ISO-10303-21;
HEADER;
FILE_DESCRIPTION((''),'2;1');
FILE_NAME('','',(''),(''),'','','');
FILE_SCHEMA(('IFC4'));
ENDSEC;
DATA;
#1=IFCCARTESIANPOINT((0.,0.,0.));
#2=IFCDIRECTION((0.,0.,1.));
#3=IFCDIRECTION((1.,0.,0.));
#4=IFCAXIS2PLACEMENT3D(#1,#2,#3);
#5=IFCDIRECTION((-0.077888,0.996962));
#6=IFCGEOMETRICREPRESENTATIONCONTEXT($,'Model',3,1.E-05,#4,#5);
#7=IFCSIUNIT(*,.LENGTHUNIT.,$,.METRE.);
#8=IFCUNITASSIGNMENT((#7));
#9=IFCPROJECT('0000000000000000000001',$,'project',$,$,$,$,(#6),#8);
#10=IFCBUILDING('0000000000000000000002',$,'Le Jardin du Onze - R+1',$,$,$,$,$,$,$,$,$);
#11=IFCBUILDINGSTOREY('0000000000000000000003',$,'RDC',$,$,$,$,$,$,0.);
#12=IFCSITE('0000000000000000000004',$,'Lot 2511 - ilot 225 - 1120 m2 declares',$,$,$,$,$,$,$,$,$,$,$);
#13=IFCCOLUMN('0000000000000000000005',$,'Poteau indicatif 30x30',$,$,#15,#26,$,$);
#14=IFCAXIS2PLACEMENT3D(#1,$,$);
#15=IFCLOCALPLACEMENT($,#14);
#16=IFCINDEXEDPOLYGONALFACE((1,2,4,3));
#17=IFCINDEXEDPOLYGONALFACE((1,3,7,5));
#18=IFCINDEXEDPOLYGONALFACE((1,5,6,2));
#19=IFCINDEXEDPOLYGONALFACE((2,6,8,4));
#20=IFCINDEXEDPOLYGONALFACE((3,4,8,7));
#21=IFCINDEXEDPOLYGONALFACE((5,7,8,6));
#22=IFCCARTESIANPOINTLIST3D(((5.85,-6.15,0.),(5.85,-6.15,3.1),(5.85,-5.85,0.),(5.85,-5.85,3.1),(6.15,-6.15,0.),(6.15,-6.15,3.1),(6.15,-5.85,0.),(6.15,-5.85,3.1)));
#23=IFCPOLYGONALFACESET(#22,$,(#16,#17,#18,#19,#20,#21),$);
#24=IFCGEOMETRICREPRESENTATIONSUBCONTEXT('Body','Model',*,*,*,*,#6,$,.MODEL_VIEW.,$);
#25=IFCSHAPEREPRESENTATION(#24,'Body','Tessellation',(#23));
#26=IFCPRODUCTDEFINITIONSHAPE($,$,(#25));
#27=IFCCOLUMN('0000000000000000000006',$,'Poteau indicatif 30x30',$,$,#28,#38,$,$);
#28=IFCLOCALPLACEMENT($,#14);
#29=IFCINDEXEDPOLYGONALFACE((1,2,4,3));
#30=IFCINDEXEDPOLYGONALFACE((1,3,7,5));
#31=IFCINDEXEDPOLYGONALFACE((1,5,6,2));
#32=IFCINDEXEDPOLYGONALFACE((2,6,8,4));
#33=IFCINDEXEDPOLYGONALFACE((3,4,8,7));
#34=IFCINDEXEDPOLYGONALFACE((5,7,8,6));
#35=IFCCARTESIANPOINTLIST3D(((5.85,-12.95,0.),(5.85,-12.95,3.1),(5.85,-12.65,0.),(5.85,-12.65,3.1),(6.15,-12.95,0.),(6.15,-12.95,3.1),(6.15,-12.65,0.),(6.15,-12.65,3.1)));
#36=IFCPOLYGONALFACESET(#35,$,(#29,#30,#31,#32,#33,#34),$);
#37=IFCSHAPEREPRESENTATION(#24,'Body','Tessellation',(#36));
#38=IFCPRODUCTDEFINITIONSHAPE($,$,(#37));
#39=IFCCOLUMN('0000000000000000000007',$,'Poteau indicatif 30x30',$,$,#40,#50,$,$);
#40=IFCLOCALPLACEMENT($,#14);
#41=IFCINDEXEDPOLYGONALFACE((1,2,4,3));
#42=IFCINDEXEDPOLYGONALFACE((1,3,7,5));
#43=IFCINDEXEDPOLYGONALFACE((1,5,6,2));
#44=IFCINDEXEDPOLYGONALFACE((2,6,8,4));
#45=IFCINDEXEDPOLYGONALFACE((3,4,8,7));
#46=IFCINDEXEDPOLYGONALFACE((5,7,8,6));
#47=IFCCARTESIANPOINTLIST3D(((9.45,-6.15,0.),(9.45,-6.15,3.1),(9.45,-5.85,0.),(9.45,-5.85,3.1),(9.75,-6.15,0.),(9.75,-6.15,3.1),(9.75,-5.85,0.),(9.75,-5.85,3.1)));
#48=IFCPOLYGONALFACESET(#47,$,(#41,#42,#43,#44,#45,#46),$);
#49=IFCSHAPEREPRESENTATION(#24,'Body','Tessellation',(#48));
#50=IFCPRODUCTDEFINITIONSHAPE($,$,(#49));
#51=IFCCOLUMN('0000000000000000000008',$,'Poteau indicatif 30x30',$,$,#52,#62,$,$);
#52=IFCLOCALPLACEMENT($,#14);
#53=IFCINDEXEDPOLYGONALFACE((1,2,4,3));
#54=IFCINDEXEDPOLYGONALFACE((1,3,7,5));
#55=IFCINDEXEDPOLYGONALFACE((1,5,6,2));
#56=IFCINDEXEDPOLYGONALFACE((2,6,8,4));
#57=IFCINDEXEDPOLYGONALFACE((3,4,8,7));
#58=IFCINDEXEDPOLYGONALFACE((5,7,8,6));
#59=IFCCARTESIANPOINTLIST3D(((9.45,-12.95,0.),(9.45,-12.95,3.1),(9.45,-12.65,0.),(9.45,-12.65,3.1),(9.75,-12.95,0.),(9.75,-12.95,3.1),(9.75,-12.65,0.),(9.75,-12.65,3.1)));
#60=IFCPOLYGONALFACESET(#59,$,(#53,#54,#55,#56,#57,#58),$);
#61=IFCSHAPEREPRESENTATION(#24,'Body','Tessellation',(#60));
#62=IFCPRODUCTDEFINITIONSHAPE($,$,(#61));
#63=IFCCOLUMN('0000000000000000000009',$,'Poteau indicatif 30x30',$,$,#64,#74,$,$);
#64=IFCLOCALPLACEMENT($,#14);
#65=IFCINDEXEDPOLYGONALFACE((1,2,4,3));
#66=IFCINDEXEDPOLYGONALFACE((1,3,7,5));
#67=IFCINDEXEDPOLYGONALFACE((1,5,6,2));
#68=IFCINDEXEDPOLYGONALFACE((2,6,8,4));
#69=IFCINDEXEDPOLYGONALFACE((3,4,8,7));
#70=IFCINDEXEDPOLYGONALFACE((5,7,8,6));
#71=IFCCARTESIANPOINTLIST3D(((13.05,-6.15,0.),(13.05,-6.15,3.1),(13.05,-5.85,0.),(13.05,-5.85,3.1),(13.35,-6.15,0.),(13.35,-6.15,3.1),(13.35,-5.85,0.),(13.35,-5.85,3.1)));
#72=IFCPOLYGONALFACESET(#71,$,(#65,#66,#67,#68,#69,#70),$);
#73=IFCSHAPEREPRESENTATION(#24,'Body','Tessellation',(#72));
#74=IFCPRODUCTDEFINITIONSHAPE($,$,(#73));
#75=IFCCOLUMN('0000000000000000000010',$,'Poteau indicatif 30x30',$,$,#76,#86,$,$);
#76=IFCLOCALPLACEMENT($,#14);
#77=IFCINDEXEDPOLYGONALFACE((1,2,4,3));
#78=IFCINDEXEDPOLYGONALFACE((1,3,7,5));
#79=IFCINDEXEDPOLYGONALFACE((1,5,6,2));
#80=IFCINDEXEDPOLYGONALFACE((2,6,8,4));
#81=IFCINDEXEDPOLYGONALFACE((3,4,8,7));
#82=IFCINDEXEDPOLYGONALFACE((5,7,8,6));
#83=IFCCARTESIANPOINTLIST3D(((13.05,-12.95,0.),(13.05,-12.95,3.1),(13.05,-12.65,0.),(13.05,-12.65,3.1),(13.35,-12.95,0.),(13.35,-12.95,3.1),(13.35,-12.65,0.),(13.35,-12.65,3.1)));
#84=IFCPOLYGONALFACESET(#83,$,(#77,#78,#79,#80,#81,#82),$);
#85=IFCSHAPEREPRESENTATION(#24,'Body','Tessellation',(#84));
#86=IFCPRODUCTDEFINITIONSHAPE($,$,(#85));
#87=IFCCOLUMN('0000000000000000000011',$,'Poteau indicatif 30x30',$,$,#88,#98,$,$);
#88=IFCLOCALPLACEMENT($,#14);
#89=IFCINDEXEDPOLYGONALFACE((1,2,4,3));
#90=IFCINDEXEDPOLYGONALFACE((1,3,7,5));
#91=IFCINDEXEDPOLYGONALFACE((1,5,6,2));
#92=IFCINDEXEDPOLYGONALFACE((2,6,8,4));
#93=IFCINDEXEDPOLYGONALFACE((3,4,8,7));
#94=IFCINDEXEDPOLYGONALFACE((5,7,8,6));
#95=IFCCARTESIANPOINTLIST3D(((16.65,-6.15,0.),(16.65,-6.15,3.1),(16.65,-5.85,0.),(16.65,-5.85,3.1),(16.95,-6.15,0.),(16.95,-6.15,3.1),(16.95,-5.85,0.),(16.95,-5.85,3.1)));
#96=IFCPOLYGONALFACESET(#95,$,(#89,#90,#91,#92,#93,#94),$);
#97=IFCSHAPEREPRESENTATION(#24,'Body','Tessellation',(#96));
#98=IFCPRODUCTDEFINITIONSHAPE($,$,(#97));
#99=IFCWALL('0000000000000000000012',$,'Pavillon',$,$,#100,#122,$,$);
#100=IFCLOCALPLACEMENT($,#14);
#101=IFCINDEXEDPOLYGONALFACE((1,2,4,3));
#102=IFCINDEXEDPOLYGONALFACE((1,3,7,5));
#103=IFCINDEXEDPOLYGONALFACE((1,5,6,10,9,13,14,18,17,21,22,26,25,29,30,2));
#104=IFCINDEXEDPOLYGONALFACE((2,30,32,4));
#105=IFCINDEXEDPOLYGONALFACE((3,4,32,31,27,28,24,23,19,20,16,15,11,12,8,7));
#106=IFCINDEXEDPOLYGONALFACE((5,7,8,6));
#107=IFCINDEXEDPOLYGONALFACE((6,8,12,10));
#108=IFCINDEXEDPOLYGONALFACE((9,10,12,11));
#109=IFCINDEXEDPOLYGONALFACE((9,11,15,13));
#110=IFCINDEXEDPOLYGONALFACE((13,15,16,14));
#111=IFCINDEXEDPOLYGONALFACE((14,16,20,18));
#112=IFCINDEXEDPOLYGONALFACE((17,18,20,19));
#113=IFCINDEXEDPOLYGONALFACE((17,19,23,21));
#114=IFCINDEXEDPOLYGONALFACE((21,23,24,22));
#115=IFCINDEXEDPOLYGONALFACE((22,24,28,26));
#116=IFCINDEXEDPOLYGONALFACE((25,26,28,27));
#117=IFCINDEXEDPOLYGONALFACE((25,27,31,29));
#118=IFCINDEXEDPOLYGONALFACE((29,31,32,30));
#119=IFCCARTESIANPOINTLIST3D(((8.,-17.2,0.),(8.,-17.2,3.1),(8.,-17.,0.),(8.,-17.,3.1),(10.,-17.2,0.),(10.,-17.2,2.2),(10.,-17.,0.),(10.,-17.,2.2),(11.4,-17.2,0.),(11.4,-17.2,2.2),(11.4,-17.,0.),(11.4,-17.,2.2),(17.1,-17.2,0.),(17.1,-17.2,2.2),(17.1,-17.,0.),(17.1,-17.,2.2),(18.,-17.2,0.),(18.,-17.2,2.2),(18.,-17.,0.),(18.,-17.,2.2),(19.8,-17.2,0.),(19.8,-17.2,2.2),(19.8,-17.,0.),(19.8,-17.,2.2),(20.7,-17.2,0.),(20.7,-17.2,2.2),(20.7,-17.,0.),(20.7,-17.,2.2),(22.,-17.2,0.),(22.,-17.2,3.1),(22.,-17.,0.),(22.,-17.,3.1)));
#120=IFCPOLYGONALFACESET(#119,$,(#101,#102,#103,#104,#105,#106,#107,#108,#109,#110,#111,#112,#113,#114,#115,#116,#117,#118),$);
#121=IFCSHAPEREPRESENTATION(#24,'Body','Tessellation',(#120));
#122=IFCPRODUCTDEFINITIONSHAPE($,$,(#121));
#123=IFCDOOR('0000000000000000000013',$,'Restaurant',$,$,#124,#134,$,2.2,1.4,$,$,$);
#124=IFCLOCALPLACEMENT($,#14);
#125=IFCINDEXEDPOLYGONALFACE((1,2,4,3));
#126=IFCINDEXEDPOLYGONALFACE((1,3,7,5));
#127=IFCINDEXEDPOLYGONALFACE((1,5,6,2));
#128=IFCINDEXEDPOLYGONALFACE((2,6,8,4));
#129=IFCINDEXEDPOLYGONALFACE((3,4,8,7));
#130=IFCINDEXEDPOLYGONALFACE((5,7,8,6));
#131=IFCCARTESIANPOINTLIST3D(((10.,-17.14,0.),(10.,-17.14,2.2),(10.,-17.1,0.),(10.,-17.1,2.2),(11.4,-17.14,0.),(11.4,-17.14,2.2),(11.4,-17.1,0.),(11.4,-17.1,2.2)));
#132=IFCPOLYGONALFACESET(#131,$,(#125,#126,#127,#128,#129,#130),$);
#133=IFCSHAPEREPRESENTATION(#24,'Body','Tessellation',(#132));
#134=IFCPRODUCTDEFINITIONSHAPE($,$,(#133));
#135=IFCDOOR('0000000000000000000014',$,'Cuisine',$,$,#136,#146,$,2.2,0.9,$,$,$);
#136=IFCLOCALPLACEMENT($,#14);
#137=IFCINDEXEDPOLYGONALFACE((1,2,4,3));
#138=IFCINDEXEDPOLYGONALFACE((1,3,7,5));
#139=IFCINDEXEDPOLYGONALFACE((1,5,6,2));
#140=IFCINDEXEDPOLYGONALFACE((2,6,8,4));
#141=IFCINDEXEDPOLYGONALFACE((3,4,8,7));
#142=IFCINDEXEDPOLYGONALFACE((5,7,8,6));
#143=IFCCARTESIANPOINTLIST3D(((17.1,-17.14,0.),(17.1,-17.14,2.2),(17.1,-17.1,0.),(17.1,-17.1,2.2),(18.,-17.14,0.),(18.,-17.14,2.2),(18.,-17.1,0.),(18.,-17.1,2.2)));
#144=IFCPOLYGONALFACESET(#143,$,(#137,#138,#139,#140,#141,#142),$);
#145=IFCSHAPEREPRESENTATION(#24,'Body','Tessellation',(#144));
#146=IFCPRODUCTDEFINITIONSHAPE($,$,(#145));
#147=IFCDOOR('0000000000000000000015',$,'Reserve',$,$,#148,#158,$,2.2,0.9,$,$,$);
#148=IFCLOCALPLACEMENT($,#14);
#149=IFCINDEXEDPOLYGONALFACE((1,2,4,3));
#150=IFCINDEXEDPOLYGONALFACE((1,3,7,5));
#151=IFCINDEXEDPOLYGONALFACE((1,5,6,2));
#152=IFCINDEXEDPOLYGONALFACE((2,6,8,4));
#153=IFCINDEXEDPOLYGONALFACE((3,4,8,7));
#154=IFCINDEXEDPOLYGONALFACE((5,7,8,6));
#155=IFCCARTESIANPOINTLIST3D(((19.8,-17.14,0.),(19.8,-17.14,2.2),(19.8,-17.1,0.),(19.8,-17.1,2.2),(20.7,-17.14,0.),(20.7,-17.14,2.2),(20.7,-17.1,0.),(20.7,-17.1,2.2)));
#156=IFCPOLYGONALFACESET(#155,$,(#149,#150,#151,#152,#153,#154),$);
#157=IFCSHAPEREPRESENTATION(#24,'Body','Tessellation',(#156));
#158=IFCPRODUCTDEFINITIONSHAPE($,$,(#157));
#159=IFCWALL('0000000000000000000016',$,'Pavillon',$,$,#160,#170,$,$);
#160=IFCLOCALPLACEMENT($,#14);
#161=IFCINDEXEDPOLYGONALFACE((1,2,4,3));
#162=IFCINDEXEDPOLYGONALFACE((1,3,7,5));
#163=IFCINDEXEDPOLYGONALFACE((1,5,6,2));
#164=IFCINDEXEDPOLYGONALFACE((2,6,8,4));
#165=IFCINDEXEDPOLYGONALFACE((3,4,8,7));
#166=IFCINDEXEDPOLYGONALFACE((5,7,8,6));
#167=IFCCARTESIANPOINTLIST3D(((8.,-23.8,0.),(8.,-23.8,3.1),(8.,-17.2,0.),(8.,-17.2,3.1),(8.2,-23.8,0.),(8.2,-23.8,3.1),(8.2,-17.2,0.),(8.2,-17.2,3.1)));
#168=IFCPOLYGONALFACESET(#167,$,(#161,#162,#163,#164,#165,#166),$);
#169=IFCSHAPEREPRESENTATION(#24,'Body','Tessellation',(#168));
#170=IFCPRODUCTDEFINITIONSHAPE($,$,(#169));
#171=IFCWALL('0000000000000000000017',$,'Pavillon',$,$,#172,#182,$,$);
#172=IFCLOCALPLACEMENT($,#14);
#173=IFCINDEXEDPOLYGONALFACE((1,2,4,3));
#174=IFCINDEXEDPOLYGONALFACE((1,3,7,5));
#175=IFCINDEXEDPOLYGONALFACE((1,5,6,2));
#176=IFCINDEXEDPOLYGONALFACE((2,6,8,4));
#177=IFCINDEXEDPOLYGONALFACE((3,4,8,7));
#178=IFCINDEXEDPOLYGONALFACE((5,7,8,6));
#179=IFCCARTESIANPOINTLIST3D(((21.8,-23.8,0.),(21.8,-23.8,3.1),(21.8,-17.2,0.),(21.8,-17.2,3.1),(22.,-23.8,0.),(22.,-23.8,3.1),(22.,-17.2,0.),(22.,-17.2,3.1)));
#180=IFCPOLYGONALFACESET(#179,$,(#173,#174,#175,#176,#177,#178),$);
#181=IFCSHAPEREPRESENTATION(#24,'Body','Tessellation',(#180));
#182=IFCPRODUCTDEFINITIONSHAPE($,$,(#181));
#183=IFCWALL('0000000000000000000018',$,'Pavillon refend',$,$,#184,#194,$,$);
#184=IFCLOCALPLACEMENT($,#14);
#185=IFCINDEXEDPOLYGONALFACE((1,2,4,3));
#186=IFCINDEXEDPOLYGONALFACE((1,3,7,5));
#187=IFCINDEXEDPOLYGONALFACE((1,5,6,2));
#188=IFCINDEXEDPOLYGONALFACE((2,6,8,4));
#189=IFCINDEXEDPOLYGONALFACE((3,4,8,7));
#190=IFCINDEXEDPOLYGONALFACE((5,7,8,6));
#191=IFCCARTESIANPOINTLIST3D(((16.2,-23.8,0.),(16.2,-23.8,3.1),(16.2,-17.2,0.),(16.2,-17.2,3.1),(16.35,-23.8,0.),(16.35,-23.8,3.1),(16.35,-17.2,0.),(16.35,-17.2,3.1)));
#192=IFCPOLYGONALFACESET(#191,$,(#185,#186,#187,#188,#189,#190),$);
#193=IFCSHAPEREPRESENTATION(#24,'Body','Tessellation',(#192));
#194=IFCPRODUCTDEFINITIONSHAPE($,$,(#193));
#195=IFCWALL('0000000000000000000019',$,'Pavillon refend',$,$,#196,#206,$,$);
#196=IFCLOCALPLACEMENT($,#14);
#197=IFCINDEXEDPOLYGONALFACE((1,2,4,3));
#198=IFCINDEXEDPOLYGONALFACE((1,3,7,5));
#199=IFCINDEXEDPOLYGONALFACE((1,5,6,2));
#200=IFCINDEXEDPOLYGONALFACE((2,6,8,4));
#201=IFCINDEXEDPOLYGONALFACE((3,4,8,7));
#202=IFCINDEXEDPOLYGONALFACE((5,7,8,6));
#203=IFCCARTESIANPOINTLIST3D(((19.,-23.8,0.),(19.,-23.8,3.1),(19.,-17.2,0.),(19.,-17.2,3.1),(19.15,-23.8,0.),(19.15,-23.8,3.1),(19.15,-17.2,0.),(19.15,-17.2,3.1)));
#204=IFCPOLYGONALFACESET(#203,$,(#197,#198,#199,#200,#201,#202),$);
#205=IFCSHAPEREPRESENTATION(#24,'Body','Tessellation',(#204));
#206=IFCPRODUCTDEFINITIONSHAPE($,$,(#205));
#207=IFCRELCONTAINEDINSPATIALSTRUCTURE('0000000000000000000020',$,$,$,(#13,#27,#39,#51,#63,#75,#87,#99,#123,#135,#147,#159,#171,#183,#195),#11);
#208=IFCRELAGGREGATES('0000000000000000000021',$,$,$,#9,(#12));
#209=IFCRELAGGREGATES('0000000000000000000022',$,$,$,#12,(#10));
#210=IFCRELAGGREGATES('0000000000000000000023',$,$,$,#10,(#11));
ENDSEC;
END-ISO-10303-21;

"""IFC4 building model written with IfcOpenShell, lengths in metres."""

from ifc_helpers import new_model, si_unit, direction, origin, origin_with_axes, place, context, subcontext, project, spatial, polyline, outline, extrude, element, fill, save


model = new_model("IFC4")

# Units and contexts
model_context = context("Model", 3, precision=1e-05, world=origin_with_axes(), true_north=direction((-0.077888, 0.996962)))
body_context = subcontext(model_context, "Body", "Model", "MODEL_VIEW")
ifc_project = project(units=[si_unit("LENGTHUNIT", "METRE")], contexts=[model_context])

# Site, building, storey
site = spatial("IfcSite", under=ifc_project, Name="Lot 2511 - ilot 225 - 1120 m2 declares")
building = spatial("IfcBuilding", under=site, Name="Le Jardin du Onze - R+1")
storey = spatial("IfcBuildingStorey", under=building, Name="RDC", Elevation=0.0)

# Columns
column_1_placement = place(None, origin_with_axes())
element("IfcColumn", 1, at=column_1_placement, inside=storey, Name="Poteau indicatif 30x30", context=body_context, shape_type="SweptSolid", body=[
    extrude(outline(polyline([(6.15, -6.15), (6.15, -5.85), (5.85, -5.85), (5.85, -6.15), (6.15, -6.15)])), origin(), (0.0, 0.0, 1.0), 3.1),
])
column_2_placement = place(None, origin_with_axes())
element("IfcColumn", 2, at=column_2_placement, inside=storey, Name="Poteau indicatif 30x30", context=body_context, shape_type="SweptSolid", body=[
    extrude(outline(polyline([(6.15, -12.95), (6.15, -12.65), (5.85, -12.65), (5.85, -12.95), (6.15, -12.95)])), origin(), (0.0, 0.0, 1.0), 3.1),
])
column_3_placement = place(None, origin_with_axes())
element("IfcColumn", 3, at=column_3_placement, inside=storey, Name="Poteau indicatif 30x30", context=body_context, shape_type="SweptSolid", body=[
    extrude(outline(polyline([(9.75, -6.15), (9.75, -5.85), (9.45, -5.85), (9.45, -6.15), (9.75, -6.15)])), origin(), (0.0, 0.0, 1.0), 3.1),
])
column_4_placement = place(None, origin_with_axes())
element("IfcColumn", 4, at=column_4_placement, inside=storey, Name="Poteau indicatif 30x30", context=body_context, shape_type="SweptSolid", body=[
    extrude(outline(polyline([(9.75, -12.95), (9.75, -12.65), (9.45, -12.65), (9.45, -12.95), (9.75, -12.95)])), origin(), (0.0, 0.0, 1.0), 3.1),
])
column_5_placement = place(None, origin_with_axes())
element("IfcColumn", 5, at=column_5_placement, inside=storey, Name="Poteau indicatif 30x30", context=body_context, shape_type="SweptSolid", body=[
    extrude(outline(polyline([(13.35, -6.15), (13.35, -5.85), (13.05, -5.85), (13.05, -6.15), (13.35, -6.15)])), origin(), (0.0, 0.0, 1.0), 3.1),
])
column_6_placement = place(None, origin_with_axes())
element("IfcColumn", 6, at=column_6_placement, inside=storey, Name="Poteau indicatif 30x30", context=body_context, shape_type="SweptSolid", body=[
    extrude(outline(polyline([(13.35, -12.95), (13.35, -12.65), (13.05, -12.65), (13.05, -12.95), (13.35, -12.95)])), origin(), (0.0, 0.0, 1.0), 3.1),
])
column_7_placement = place(None, origin_with_axes())
element("IfcColumn", 7, at=column_7_placement, inside=storey, Name="Poteau indicatif 30x30", context=body_context, shape_type="SweptSolid", body=[
    extrude(outline(polyline([(16.95, -6.15), (16.95, -5.85), (16.65, -5.85), (16.65, -6.15), (16.95, -6.15)])), origin(), (0.0, 0.0, 1.0), 3.1),
])

# Wall, openings, doors
wall_1_placement = place(None, origin_with_axes())
wall_1 = element("IfcWall", 8, at=wall_1_placement, inside=storey, Name="Pavillon", context=body_context, shape_type="SweptSolid", body=[
    extrude(outline(polyline([(22.0, -17.2), (22.0, -17.0), (8.0, -17.0), (8.0, -17.2), (22.0, -17.2)])), origin(), (0.0, 0.0, 1.0), 3.1),
])
opening_1_placement = place(None, origin_with_axes())
opening_1 = element("IfcOpeningElement", 9, at=opening_1_placement, cuts=wall_1, context=body_context, shape_type="SweptSolid", body=[
    extrude(outline(polyline([(11.4, -17.24), (11.4, -16.96), (10.0, -16.96), (10.0, -17.24), (11.4, -17.24)])), origin(), (0.0, 0.0, 1.0), 2.2),
])
opening_2_placement = place(None, origin_with_axes())
opening_2 = element("IfcOpeningElement", 10, at=opening_2_placement, cuts=wall_1, context=body_context, shape_type="SweptSolid", body=[
    extrude(outline(polyline([(18.0, -17.24), (18.0, -16.96), (17.1, -16.96), (17.1, -17.24), (18.0, -17.24)])), origin(), (0.0, 0.0, 1.0), 2.2),
])
opening_3_placement = place(None, origin_with_axes())
opening_3 = element("IfcOpeningElement", 11, at=opening_3_placement, cuts=wall_1, context=body_context, shape_type="SweptSolid", body=[
    extrude(outline(polyline([(20.7, -17.24), (20.7, -16.96), (19.8, -16.96), (19.8, -17.24), (20.7, -17.24)])), origin(), (0.0, 0.0, 1.0), 2.2),
])
door_1_placement = place(None, origin_with_axes())
door_1 = element("IfcDoor", 12, at=door_1_placement, inside=storey, Name="Restaurant", OverallHeight=2.2, OverallWidth=1.4, context=body_context, shape_type="SweptSolid", body=[
    extrude(outline(polyline([(11.4, -17.14), (11.4, -17.1), (10.0, -17.1), (10.0, -17.14), (11.4, -17.14)])), origin(), (0.0, 0.0, 1.0), 2.2),
])
fill(opening_1, door_1)
door_2_placement = place(None, origin_with_axes())
door_2 = element("IfcDoor", 13, at=door_2_placement, inside=storey, Name="Cuisine", OverallHeight=2.2, OverallWidth=0.9, context=body_context, shape_type="SweptSolid", body=[
    extrude(outline(polyline([(18.0, -17.14), (18.0, -17.1), (17.1, -17.1), (17.1, -17.14), (18.0, -17.14)])), origin(), (0.0, 0.0, 1.0), 2.2),
])
fill(opening_2, door_2)
door_3_placement = place(None, origin_with_axes())
door_3 = element("IfcDoor", 14, at=door_3_placement, inside=storey, Name="Reserve", OverallHeight=2.2, OverallWidth=0.9, context=body_context, shape_type="SweptSolid", body=[
    extrude(outline(polyline([(20.7, -17.14), (20.7, -17.1), (19.8, -17.1), (19.8, -17.14), (20.7, -17.14)])), origin(), (0.0, 0.0, 1.0), 2.2),
])
fill(opening_3, door_3)

# Walls
wall_2_placement = place(None, origin_with_axes())
element("IfcWall", 15, at=wall_2_placement, inside=storey, Name="Pavillon", context=body_context, shape_type="SweptSolid", body=[
    extrude(outline(polyline([(8.2, -23.8), (8.2, -17.2), (8.0, -17.2), (8.0, -23.8), (8.2, -23.8)])), origin(), (0.0, 0.0, 1.0), 3.1),
])
wall_3_placement = place(None, origin_with_axes())
element("IfcWall", 16, at=wall_3_placement, inside=storey, Name="Pavillon", context=body_context, shape_type="SweptSolid", body=[
    extrude(outline(polyline([(22.0, -23.8), (22.0, -17.2), (21.8, -17.2), (21.8, -23.8), (22.0, -23.8)])), origin(), (0.0, 0.0, 1.0), 3.1),
])
wall_4_placement = place(None, origin_with_axes())
element("IfcWall", 17, at=wall_4_placement, inside=storey, Name="Pavillon refend", context=body_context, shape_type="SweptSolid", body=[
    extrude(outline(polyline([(16.35, -23.8), (16.35, -17.2), (16.2, -17.2), (16.2, -23.8), (16.35, -23.8)])), origin(), (0.0, 0.0, 1.0), 3.1),
])
wall_5_placement = place(None, origin_with_axes())
element("IfcWall", 18, at=wall_5_placement, inside=storey, Name="Pavillon refend", context=body_context, shape_type="SweptSolid", body=[
    extrude(outline(polyline([(19.15, -23.8), (19.15, -17.2), (19.0, -17.2), (19.0, -23.8), (19.15, -23.8)])), origin(), (0.0, 0.0, 1.0), 3.1),
])

save(model, "model.ifc")
